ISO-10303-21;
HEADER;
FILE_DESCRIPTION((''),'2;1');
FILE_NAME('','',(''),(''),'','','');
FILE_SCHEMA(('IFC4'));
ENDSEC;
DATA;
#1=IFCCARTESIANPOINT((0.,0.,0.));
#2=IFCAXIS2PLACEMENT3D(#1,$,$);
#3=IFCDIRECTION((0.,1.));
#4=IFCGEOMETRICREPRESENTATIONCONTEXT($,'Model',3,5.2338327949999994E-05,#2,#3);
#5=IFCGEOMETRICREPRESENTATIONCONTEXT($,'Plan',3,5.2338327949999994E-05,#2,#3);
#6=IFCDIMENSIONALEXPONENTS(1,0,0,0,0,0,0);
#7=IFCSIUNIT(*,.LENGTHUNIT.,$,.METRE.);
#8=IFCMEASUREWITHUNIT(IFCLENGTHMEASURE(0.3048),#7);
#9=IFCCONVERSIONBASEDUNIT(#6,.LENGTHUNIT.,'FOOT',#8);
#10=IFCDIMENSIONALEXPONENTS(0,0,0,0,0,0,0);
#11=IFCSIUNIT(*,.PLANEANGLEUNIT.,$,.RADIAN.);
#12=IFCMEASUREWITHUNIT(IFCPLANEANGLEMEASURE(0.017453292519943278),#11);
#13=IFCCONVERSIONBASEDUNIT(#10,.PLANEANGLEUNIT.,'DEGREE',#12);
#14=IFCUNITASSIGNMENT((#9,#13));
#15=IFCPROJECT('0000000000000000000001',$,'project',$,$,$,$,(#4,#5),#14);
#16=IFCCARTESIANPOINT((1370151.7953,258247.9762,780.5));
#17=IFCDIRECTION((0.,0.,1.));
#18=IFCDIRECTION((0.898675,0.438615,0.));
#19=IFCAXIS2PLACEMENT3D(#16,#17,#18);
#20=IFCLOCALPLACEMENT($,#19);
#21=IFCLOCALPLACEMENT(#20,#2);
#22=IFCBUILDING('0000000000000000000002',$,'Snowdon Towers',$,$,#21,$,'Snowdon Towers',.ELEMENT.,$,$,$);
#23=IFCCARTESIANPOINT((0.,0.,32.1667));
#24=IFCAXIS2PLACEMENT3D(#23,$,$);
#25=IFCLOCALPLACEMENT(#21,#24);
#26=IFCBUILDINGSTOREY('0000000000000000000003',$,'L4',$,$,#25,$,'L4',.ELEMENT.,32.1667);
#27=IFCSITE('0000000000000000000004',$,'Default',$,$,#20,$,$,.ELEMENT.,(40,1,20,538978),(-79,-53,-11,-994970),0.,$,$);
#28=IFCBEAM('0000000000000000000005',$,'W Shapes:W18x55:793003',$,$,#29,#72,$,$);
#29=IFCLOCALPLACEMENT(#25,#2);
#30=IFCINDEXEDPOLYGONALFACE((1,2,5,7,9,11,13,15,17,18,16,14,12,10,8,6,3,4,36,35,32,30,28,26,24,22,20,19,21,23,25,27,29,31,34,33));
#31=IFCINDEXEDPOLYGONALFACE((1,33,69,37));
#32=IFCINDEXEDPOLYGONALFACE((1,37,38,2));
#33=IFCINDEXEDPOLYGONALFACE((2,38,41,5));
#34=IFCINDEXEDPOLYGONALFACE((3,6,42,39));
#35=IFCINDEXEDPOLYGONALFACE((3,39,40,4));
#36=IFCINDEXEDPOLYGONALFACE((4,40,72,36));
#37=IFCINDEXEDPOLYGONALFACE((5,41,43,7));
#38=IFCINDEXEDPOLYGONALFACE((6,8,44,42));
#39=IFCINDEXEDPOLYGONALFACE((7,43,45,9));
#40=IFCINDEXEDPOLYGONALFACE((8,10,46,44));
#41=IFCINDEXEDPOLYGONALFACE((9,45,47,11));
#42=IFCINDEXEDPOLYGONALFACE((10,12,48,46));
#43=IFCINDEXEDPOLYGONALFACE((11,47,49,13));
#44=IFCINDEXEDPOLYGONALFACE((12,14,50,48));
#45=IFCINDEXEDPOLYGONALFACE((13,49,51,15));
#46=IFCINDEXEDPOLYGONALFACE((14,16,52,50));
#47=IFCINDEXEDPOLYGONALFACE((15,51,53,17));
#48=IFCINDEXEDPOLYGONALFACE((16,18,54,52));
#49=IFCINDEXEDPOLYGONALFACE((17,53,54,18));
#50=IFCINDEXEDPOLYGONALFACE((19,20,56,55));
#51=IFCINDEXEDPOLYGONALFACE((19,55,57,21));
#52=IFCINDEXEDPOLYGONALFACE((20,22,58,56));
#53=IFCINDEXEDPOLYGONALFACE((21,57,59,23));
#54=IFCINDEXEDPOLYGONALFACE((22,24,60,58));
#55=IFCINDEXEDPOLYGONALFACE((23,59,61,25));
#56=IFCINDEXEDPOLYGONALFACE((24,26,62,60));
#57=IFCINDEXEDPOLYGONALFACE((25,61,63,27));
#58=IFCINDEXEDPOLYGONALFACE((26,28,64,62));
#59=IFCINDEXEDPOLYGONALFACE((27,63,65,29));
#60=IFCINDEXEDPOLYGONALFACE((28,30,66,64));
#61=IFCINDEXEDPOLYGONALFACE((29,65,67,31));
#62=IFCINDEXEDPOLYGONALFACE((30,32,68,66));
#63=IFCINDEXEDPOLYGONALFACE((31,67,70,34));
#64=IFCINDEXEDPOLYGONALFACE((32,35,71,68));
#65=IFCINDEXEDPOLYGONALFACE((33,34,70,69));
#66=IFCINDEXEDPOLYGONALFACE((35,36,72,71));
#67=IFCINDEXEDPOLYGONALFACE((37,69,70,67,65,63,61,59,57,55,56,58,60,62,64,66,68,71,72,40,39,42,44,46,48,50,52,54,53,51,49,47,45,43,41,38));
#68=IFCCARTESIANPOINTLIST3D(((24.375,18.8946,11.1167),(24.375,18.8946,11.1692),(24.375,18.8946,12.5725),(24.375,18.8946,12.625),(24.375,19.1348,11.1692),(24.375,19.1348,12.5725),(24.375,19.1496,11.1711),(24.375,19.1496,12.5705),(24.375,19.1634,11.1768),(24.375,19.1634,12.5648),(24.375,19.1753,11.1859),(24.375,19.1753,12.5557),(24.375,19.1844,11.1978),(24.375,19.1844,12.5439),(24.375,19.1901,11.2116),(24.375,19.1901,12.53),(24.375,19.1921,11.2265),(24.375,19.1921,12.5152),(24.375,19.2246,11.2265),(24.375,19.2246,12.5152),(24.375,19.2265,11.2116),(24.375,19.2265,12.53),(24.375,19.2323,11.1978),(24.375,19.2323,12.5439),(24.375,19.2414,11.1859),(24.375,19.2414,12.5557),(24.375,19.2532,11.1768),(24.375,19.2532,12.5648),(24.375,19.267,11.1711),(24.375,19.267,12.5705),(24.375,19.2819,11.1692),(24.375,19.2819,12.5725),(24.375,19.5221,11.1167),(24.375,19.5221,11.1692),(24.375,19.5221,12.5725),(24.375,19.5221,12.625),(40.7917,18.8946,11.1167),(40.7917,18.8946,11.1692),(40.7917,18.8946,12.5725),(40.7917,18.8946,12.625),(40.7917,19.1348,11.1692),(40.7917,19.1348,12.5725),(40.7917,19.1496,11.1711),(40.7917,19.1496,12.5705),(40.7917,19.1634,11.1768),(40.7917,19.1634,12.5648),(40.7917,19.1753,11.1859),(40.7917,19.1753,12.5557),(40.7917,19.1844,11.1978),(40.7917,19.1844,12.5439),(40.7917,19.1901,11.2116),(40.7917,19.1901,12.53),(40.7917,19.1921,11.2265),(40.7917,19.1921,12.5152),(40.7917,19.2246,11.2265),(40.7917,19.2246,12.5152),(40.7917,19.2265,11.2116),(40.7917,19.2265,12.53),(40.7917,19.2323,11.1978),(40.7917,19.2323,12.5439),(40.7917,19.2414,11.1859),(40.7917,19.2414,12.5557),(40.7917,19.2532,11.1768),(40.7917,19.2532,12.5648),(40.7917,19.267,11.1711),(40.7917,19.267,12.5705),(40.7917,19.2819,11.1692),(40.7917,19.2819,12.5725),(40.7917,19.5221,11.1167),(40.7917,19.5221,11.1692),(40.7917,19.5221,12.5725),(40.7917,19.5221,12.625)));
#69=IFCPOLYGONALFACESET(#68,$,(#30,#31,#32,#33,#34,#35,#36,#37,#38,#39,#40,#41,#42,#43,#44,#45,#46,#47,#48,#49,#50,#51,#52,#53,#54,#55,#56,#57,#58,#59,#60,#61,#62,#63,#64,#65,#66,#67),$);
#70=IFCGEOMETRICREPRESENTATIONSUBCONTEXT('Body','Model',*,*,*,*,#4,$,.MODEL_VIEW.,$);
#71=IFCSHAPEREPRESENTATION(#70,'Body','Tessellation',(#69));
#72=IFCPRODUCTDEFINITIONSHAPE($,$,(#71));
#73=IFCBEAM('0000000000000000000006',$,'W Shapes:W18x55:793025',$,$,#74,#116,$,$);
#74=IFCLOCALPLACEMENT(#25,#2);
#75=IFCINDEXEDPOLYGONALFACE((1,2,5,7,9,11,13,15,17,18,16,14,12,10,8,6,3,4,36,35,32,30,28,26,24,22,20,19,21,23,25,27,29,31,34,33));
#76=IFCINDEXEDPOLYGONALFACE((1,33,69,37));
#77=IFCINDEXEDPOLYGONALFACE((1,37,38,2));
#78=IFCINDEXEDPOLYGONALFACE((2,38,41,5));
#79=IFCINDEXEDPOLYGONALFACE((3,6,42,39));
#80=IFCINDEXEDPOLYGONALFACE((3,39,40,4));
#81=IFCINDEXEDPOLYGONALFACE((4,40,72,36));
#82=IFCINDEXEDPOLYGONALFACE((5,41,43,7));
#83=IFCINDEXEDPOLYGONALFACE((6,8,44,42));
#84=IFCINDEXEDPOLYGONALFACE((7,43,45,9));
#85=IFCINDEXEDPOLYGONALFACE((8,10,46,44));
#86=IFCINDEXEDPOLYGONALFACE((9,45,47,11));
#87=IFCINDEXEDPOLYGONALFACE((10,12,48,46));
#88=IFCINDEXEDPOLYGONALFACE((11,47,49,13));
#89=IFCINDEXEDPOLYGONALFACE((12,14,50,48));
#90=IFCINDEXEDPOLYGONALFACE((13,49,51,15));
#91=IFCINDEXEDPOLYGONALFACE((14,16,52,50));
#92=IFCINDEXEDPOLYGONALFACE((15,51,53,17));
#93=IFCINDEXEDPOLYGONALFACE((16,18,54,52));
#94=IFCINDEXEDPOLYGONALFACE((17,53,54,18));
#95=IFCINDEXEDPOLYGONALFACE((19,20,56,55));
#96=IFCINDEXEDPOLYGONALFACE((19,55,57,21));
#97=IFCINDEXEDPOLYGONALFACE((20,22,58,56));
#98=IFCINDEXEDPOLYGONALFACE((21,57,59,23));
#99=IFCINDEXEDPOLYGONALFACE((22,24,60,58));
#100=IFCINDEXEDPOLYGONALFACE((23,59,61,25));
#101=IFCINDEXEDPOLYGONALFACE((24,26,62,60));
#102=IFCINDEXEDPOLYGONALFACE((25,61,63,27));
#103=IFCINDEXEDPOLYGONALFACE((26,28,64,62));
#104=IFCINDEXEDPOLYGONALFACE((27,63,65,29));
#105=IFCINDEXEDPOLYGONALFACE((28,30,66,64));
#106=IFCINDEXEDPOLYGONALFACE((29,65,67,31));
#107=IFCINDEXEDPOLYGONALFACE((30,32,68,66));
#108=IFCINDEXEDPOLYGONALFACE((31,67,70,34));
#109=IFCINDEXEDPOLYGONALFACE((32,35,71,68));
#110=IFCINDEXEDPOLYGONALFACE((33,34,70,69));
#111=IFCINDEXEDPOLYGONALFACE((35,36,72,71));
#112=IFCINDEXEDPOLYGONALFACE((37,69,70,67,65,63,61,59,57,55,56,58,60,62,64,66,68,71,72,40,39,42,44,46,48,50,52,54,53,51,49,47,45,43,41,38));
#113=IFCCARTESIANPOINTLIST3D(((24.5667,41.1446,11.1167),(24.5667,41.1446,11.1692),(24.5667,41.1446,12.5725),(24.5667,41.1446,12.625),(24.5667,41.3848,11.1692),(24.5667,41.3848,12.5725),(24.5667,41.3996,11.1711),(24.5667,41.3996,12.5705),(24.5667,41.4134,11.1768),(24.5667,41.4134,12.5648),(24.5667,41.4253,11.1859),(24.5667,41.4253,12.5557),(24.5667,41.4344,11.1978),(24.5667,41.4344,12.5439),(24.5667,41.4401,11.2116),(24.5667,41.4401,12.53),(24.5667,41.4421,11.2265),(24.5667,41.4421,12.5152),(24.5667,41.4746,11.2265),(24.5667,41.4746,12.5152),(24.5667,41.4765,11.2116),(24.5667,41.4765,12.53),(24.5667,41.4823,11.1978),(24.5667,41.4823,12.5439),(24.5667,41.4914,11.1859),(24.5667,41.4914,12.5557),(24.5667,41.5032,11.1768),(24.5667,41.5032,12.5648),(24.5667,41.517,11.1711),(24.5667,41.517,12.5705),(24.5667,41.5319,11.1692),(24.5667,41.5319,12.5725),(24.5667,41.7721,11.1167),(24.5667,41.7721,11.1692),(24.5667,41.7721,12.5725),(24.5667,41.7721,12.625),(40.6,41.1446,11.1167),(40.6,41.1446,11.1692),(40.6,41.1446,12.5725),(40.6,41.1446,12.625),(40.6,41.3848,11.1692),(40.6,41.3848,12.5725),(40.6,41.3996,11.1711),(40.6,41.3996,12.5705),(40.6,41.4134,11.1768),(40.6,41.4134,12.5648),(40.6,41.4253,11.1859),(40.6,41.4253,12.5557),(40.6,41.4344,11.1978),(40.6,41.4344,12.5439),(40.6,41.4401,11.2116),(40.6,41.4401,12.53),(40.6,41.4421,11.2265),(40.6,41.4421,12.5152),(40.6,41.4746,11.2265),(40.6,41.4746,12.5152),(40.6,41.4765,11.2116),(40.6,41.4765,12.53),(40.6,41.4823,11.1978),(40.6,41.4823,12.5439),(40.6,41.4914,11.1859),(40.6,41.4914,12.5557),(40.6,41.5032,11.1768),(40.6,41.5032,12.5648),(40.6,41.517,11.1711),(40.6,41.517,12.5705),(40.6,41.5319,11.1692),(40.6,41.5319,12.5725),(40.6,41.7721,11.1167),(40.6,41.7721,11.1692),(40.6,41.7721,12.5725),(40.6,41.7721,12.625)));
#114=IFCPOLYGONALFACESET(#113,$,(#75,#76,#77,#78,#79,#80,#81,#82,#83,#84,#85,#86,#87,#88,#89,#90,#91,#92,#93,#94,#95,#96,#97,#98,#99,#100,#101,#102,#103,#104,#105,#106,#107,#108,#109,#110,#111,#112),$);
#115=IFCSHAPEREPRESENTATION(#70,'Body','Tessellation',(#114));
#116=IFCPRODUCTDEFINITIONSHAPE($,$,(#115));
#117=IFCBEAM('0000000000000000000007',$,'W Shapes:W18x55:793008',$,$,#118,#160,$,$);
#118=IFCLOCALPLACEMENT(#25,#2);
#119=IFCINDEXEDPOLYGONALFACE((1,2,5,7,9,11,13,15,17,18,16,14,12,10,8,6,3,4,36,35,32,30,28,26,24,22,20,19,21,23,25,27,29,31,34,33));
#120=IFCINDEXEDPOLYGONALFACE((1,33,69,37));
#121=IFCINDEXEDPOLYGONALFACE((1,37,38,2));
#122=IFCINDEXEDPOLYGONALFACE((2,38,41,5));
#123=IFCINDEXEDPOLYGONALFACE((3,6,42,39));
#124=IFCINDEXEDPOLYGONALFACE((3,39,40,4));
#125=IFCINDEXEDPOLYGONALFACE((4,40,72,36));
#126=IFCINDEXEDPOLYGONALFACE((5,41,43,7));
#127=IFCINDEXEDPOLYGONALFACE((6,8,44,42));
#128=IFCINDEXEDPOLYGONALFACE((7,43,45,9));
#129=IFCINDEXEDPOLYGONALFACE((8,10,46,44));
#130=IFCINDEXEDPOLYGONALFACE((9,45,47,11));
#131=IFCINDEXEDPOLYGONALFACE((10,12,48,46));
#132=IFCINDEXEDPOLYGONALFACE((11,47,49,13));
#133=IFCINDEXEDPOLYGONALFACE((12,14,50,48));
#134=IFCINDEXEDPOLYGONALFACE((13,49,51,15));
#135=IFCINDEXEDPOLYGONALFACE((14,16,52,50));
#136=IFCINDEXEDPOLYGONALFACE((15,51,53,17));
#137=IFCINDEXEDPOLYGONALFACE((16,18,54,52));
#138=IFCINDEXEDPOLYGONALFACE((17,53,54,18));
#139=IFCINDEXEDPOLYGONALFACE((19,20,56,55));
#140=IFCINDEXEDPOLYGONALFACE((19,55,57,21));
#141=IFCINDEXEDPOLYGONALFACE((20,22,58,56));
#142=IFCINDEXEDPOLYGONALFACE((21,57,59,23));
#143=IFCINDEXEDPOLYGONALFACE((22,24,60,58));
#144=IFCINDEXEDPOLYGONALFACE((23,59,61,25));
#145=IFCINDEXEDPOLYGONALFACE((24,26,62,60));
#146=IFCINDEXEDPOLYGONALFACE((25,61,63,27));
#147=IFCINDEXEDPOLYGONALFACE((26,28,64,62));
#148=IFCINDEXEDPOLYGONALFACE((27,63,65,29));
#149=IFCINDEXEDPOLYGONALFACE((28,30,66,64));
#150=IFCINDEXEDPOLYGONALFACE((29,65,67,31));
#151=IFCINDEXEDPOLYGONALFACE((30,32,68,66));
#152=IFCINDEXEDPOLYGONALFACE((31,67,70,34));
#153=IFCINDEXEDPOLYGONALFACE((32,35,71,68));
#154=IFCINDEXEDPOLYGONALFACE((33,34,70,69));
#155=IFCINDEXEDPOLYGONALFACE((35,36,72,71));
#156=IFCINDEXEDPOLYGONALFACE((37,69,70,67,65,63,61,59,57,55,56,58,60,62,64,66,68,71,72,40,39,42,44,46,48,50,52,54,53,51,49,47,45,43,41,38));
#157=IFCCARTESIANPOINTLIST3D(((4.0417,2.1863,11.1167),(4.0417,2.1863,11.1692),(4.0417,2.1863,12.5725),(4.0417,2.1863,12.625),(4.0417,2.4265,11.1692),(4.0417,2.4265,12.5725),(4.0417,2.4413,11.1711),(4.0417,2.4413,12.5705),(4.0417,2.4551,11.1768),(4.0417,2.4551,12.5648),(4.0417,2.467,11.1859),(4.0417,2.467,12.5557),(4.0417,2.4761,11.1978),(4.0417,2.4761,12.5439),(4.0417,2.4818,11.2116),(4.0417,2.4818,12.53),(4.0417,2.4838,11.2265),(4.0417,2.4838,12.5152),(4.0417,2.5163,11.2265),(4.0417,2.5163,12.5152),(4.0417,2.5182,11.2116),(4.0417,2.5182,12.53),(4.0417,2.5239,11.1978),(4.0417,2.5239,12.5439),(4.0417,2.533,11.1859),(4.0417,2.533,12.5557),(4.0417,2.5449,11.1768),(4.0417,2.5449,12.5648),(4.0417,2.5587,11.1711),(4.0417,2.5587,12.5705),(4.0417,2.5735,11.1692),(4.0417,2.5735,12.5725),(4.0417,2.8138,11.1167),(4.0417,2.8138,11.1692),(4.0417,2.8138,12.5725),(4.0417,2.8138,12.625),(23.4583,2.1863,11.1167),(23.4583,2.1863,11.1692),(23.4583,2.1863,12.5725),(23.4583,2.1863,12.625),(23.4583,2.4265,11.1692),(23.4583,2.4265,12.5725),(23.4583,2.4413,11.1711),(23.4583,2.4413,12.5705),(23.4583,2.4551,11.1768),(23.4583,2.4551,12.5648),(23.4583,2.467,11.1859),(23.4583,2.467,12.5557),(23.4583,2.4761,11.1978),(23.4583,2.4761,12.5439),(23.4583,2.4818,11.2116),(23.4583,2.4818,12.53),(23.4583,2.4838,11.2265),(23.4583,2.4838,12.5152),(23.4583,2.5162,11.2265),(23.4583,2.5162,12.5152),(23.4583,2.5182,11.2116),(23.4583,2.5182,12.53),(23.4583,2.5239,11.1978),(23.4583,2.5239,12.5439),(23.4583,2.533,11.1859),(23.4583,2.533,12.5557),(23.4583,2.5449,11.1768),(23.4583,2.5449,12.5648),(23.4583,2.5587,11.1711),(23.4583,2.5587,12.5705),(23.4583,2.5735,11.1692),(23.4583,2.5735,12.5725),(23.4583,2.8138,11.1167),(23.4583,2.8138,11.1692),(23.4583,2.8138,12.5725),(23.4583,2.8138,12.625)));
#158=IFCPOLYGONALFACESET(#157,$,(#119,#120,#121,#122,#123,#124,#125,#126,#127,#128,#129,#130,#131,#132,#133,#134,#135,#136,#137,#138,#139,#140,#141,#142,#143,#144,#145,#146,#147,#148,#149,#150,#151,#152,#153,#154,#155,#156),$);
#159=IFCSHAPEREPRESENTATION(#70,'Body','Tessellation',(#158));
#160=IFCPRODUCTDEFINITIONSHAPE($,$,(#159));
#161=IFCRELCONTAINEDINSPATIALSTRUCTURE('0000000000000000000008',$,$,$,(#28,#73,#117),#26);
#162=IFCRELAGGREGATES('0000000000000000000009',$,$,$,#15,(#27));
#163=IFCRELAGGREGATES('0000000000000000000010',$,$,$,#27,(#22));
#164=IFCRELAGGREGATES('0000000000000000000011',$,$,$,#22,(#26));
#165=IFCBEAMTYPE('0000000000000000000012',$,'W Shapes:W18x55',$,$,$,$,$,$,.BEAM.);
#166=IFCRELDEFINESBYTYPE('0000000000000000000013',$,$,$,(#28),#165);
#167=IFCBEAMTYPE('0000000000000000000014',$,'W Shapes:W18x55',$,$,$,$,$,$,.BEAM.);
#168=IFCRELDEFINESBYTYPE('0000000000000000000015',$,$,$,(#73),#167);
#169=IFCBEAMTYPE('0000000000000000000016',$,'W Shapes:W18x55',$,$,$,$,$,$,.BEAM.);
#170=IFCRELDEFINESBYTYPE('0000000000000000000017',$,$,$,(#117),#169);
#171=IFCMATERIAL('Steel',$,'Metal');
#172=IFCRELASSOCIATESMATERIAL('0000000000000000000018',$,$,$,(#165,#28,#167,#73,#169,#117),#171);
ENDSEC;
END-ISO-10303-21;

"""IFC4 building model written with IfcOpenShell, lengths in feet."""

from ifc_helpers import new_model, entity, si_unit, converted_unit, direction, frame, origin, place, context, subcontext, project, spatial, line, arc, indexed_curve, outline, extrude, source, transform, mapped, material, type_object, type_shapes, element, save


model = new_model("IFC4")

# Units and contexts
model_context = context("Model", 3, precision=5.2338327949999994e-05, world=origin(), true_north=direction((0.0, 1.0)))
plan_context = context("Plan", 3, precision=5.2338327949999994e-05, world=origin(), true_north=direction((0.0, 1.0)))
body_context = subcontext(model_context, "Body", "Model", "MODEL_VIEW")
ifc_project = project(units=[converted_unit("LENGTHUNIT", "FOOT", entity("IfcLengthMeasure", 0.3048), si_unit("LENGTHUNIT", "METRE"), dimensions=[1, 0, 0, 0, 0, 0, 0]), converted_unit("PLANEANGLEUNIT", "DEGREE", entity("IfcPlaneAngleMeasure", 0.017453292519943278), si_unit("PLANEANGLEUNIT", "RADIAN"), dimensions=[0, 0, 0, 0, 0, 0, 0])], contexts=[model_context, plan_context])

# Site, building, storey
site_placement = place(None, frame((1370151.7953, 258247.9762, 780.5), z_axis=(0.0, 0.0, 1.0), x_axis=(0.898675, 0.438615, 0.0)))
site = spatial("IfcSite", under=ifc_project, at=site_placement, Name="Default", CompositionType="ELEMENT", RefLatitude=(40, 1, 20, 538978), RefLongitude=(-79, -53, -11, -994970), RefElevation=0.0)
building_placement = place(site_placement, origin())
building = spatial("IfcBuilding", under=site, at=building_placement, Name="Snowdon Towers", LongName="Snowdon Towers", CompositionType="ELEMENT")
storey_placement = place(building_placement, frame((0.0, 0.0, 32.1667)))
storey = spatial("IfcBuildingStorey", under=building, at=storey_placement, Name="L4", LongName="L4", CompositionType="ELEMENT", Elevation=32.1667)

# Beams
ifc_material = material(Name="Steel", Category="Metal")
beam_type_1 = type_object("IfcBeamType", Name="W Shapes:W18x55", PredefinedType="BEAM", material=ifc_material)
shared_shape_1 = source(origin(), body_context, "Body", "SweptSolid", [
    extrude(outline(indexed_curve([(-0.7542, -0.3138), (-0.7017, -0.3138), (-0.7017, -0.0735), (-0.6849, -0.033), (-0.6444, -0.0162), (0.6444, -0.0162), (0.6849, -0.033), (0.7017, -0.0735), (0.7017, -0.3138), (0.7542, -0.3138), (0.7542, 0.3138), (0.7017, 0.3138), (0.7017, 0.0735), (0.6849, 0.033), (0.6444, 0.0163), (-0.6444, 0.0163), (-0.6849, 0.033), (-0.7017, 0.0735), (-0.7017, 0.3137), (-0.7542, 0.3137)], segments=[line(1, 2, 3), arc(3, 4, 5), line(5, 6), arc(6, 7, 8), line(8, 9, 10, 11, 12, 13), arc(13, 14, 15), line(15, 16), arc(16, 17, 18), line(18, 19, 20, 1)], self_intersect=False)), frame((-8.2083, 0.0, 0.0), z_axis=(1.0, 0.0, 0.0), x_axis=(0.0, 0.0, -1.0)), (0.0, 0.0, 1.0), 16.4167),
])
type_shapes(beam_type_1, [shared_shape_1])
beam_1_placement = place(storey_placement, frame((32.5833, 19.2083, 11.8708)))
element("IfcBeam", 1, at=beam_1_placement, inside=storey, type_object=beam_type_1, material=ifc_material, Name="W Shapes:W18x55:793003", context=body_context, shape_type="MappedRepresentation", body=[
    mapped(shared_shape_1, transform((0.0, 0.0, 0.0), scale=1.0)),
])
beam_type_2 = type_object("IfcBeamType", Name="W Shapes:W18x55", PredefinedType="BEAM", material=ifc_material)
shared_shape_2 = source(origin(), body_context, "Body", "SweptSolid", [
    extrude(outline(indexed_curve([(-0.7542, -0.3138), (-0.7017, -0.3138), (-0.7017, -0.0735), (-0.6849, -0.033), (-0.6444, -0.0162), (0.6444, -0.0162), (0.6849, -0.033), (0.7017, -0.0735), (0.7017, -0.3138), (0.7542, -0.3138), (0.7542, 0.3138), (0.7017, 0.3138), (0.7017, 0.0735), (0.6849, 0.033), (0.6444, 0.0163), (-0.6444, 0.0163), (-0.6849, 0.033), (-0.7017, 0.0735), (-0.7017, 0.3137), (-0.7542, 0.3137)], segments=[line(1, 2, 3), arc(3, 4, 5), line(5, 6), arc(6, 7, 8), line(8, 9, 10, 11, 12, 13), arc(13, 14, 15), line(15, 16), arc(16, 17, 18), line(18, 19, 20, 1)], self_intersect=False)), frame((-8.0167, 0.0, 0.0), z_axis=(1.0, 0.0, 0.0), x_axis=(0.0, 0.0, -1.0)), (0.0, 0.0, 1.0), 16.0333),
])
type_shapes(beam_type_2, [shared_shape_2])
beam_2_placement = place(storey_placement, frame((32.5833, 41.4583, 11.8708)))
element("IfcBeam", 2, at=beam_2_placement, inside=storey, type_object=beam_type_2, material=ifc_material, Name="W Shapes:W18x55:793025", context=body_context, shape_type="MappedRepresentation", body=[
    mapped(shared_shape_2, transform((0.0, 0.0, 0.0), scale=1.0)),
])
beam_type_3 = type_object("IfcBeamType", Name="W Shapes:W18x55", PredefinedType="BEAM", material=ifc_material)
shared_shape_3 = source(origin(), body_context, "Body", "SweptSolid", [
    extrude(outline(indexed_curve([(-0.7542, -0.3138), (-0.7017, -0.3138), (-0.7017, -0.0735), (-0.6849, -0.033), (-0.6444, -0.0162), (0.6444, -0.0162), (0.6849, -0.033), (0.7017, -0.0735), (0.7017, -0.3138), (0.7542, -0.3138), (0.7542, 0.3138), (0.7017, 0.3138), (0.7017, 0.0735), (0.6849, 0.033), (0.6444, 0.0163), (-0.6444, 0.0163), (-0.6849, 0.033), (-0.7017, 0.0735), (-0.7017, 0.3137), (-0.7542, 0.3137)], segments=[line(1, 2, 3), arc(3, 4, 5), line(5, 6), arc(6, 7, 8), line(8, 9, 10, 11, 12, 13), arc(13, 14, 15), line(15, 16), arc(16, 17, 18), line(18, 19, 20, 1)], self_intersect=False)), frame((-9.7917, 0.0, 0.0), z_axis=(1.0, 0.0, 0.0), x_axis=(0.0, 0.0, -1.0)), (0.0, 0.0, 1.0), 19.4167),
])
type_shapes(beam_type_3, [shared_shape_3])
beam_3_placement = place(storey_placement, frame((13.8333, 2.5, 11.8708)))
element("IfcBeam", 3, at=beam_3_placement, inside=storey, type_object=beam_type_3, material=ifc_material, Name="W Shapes:W18x55:793008", context=body_context, shape_type="MappedRepresentation", body=[
    mapped(shared_shape_3, transform((0.0, 0.0, 0.0), scale=1.0)),
])

save(model, "model.ifc")
